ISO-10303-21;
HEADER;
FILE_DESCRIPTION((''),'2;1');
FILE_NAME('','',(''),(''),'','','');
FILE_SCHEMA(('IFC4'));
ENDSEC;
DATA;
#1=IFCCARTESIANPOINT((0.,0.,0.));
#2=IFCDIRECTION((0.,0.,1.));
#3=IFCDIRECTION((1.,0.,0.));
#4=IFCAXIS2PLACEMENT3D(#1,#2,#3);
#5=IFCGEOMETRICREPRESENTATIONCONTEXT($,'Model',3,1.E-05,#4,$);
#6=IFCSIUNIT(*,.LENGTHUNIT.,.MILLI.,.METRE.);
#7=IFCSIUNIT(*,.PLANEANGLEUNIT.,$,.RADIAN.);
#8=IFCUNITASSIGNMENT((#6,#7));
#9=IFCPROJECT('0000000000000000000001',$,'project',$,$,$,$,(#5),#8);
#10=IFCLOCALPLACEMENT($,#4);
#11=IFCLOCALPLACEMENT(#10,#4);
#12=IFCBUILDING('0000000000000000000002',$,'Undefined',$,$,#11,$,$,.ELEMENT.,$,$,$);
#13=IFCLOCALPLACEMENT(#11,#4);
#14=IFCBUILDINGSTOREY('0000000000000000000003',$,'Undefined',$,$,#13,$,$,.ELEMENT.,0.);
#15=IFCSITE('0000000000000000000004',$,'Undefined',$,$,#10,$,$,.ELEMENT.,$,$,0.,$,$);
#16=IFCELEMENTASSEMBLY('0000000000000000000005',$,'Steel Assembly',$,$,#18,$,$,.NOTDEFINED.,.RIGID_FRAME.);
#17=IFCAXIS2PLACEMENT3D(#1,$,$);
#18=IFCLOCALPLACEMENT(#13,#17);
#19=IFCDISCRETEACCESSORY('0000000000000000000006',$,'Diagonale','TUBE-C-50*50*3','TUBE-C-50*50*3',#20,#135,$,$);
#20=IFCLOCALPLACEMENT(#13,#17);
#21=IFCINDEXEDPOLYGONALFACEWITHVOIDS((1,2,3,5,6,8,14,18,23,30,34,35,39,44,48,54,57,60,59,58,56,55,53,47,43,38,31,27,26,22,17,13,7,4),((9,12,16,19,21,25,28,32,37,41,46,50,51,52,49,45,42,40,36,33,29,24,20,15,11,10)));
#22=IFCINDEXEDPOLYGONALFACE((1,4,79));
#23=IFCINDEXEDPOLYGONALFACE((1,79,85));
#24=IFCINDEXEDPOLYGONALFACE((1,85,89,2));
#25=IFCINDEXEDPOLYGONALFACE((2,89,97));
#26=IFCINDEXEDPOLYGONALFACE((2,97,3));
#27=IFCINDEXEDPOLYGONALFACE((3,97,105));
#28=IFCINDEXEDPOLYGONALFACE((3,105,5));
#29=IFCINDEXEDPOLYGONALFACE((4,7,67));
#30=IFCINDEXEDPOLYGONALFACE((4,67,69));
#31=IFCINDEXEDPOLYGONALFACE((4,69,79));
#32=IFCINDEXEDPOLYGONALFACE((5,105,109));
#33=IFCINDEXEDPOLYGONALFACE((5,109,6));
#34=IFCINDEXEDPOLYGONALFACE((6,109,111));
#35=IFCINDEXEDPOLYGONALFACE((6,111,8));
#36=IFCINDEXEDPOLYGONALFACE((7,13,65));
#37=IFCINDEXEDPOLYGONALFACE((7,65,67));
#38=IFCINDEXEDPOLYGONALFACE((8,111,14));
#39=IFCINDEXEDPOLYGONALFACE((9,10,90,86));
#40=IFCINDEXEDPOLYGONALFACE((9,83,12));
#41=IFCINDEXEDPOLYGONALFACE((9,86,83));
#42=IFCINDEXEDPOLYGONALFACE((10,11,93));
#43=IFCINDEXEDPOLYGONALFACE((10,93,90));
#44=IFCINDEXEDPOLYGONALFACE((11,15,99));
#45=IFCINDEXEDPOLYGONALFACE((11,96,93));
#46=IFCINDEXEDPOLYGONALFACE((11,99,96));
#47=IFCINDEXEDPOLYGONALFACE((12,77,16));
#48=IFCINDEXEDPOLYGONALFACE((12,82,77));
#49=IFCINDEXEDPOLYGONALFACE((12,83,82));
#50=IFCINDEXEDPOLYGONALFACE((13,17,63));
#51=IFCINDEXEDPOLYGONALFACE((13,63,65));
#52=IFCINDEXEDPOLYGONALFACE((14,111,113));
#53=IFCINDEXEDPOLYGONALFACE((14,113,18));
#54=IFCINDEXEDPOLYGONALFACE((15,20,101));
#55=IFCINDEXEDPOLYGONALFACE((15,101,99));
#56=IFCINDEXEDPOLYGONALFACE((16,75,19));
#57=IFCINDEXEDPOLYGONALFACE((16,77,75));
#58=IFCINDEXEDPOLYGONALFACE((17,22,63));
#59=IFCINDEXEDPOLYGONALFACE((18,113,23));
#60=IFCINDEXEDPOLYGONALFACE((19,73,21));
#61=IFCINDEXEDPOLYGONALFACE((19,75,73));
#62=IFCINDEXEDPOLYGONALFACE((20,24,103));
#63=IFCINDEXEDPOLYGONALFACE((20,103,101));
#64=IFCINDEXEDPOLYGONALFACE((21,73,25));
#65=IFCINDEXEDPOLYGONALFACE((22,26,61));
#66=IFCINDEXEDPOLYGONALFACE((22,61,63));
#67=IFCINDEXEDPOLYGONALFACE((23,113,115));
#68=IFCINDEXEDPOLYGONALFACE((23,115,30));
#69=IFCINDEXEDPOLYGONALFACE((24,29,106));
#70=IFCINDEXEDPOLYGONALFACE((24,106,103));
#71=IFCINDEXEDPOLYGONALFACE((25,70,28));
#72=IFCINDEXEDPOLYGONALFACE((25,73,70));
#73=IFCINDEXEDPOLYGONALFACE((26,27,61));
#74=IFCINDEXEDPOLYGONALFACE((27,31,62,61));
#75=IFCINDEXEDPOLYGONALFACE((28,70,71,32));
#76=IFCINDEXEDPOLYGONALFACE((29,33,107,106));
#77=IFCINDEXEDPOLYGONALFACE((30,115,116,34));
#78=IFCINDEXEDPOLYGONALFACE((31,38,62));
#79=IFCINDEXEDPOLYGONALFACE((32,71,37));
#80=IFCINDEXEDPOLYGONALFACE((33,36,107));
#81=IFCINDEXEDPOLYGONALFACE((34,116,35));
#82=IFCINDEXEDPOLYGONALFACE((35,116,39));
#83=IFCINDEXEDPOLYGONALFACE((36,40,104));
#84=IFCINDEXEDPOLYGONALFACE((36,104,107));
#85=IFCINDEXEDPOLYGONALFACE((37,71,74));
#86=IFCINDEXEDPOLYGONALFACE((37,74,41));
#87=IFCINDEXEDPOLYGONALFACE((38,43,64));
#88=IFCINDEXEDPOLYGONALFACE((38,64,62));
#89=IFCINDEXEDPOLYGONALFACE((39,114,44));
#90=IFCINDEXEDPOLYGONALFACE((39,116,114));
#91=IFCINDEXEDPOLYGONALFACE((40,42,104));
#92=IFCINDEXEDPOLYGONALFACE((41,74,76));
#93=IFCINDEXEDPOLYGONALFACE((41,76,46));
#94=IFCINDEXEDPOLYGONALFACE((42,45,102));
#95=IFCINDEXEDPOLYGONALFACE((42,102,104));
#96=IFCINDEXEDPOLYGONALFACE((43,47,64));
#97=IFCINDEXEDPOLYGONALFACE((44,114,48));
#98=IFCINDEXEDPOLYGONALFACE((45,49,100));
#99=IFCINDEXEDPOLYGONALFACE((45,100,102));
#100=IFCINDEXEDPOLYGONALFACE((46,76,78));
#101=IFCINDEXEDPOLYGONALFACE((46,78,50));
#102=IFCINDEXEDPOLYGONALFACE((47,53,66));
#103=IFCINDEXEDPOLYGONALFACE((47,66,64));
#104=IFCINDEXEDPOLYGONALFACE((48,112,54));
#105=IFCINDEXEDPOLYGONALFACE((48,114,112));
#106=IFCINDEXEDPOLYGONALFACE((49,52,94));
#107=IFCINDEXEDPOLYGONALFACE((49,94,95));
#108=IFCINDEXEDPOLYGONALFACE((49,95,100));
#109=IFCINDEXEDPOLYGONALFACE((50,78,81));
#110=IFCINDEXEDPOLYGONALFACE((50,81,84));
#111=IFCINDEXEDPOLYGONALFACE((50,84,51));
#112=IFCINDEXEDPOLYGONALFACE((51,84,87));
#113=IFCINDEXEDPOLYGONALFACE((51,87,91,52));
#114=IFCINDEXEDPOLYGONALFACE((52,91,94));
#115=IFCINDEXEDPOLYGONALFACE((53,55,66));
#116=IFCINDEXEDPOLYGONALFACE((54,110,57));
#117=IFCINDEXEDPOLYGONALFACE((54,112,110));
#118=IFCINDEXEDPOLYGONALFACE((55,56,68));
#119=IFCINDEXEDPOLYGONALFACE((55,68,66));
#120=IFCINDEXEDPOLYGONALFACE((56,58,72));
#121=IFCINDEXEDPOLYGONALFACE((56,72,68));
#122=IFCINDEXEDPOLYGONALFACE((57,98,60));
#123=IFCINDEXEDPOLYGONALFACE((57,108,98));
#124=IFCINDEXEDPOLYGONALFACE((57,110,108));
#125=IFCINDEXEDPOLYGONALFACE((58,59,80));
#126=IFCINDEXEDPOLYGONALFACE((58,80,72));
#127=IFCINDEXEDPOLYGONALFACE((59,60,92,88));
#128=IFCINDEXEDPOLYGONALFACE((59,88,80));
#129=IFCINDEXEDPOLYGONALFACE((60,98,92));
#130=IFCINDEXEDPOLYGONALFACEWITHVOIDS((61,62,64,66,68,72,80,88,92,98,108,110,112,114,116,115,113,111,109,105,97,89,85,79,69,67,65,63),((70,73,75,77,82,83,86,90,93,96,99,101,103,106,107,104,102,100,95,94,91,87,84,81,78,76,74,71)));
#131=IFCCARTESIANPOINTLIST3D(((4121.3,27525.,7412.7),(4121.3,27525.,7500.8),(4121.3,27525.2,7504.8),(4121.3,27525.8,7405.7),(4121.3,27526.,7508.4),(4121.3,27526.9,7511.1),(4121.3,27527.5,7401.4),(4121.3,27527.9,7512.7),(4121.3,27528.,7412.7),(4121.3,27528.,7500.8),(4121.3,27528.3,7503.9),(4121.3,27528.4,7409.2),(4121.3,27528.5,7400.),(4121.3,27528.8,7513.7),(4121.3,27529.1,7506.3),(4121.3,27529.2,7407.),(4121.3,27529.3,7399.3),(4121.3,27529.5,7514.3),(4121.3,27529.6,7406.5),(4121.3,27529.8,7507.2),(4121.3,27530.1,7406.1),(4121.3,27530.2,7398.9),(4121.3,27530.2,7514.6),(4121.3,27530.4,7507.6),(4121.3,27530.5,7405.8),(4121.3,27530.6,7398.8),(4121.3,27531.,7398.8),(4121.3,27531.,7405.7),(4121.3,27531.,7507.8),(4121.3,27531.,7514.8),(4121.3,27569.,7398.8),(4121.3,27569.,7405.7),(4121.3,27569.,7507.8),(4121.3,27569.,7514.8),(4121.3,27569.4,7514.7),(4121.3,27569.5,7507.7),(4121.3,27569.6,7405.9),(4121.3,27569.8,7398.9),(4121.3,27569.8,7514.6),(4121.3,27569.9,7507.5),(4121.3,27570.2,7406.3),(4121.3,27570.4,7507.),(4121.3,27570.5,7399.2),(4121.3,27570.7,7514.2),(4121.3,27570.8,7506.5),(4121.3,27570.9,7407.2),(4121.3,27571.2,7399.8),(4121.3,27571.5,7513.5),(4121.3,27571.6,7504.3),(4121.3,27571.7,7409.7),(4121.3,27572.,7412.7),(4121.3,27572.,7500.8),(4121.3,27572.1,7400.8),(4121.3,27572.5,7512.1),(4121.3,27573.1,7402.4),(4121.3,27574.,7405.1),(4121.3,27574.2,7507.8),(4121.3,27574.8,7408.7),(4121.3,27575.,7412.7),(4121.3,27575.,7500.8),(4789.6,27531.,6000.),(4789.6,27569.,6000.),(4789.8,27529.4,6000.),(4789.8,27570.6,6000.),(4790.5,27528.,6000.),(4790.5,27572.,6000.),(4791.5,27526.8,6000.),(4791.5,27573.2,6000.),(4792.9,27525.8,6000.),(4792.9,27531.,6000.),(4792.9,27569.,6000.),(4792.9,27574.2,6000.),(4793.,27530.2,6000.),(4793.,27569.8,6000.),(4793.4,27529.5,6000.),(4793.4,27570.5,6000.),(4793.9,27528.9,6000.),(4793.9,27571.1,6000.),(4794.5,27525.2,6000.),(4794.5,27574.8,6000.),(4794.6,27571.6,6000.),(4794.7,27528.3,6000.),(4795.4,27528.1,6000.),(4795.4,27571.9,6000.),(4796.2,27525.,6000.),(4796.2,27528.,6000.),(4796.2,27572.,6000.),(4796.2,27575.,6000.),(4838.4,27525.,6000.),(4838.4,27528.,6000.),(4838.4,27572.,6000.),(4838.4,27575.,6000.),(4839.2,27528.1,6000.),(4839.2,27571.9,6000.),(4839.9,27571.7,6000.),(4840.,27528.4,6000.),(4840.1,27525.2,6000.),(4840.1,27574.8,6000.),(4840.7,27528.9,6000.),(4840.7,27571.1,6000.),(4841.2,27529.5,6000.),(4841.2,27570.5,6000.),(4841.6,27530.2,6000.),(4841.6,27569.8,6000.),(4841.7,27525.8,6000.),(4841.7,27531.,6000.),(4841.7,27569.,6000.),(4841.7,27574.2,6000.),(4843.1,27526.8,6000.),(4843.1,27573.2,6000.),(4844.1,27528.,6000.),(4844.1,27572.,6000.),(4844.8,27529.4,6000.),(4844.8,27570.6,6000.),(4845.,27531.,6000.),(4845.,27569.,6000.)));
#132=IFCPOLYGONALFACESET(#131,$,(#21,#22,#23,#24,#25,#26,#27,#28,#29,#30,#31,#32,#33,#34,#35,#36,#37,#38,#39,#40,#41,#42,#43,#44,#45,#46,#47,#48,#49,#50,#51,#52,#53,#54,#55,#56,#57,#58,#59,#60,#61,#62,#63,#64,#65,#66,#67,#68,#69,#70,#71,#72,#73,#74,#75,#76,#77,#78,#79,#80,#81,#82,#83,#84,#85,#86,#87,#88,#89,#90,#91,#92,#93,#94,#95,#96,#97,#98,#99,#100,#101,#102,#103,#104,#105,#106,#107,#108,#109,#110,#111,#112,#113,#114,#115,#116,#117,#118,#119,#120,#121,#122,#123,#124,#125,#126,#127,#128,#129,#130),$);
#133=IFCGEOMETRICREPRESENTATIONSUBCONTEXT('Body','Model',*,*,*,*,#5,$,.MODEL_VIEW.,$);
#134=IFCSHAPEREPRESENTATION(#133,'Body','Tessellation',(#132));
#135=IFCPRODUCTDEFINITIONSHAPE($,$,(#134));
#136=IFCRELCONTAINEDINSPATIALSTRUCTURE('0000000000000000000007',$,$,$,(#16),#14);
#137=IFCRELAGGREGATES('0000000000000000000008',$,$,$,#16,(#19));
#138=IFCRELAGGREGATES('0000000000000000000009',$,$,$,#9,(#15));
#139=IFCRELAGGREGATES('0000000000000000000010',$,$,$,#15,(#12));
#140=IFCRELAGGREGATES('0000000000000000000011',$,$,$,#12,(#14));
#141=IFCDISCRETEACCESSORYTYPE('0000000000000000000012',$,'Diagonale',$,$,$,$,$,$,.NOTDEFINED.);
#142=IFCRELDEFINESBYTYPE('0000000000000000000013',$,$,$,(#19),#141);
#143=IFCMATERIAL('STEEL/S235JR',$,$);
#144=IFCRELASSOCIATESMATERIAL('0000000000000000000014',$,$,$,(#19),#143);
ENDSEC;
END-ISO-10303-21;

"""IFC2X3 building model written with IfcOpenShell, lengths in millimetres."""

from ifc_helpers import new_model, si_unit, frame, origin_with_axes, origin_2d_with_axis, place, context, subcontext, project, spatial, hollow_rectangle, extrude, clip, halfspace, material, type_object, element, aggregate, save


model = new_model("IFC2X3")

# Units and contexts
model_context = context("Model", 3, precision=1e-05, world=origin_with_axes())
body_context = subcontext(model_context, "Body", "Model", "MODEL_VIEW")
ifc_project = project(units=[si_unit("LENGTHUNIT", "METRE", prefix="MILLI"), si_unit("PLANEANGLEUNIT", "RADIAN")], contexts=[model_context])

# Site, building, storey
site_placement = place(None, origin_with_axes())
site = spatial("IfcSite", under=ifc_project, at=site_placement, Name="Undefined", CompositionType="ELEMENT", RefElevation=0.0)
building_placement = place(site_placement, origin_with_axes())
building = spatial("IfcBuilding", under=site, at=building_placement, Name="Undefined", CompositionType="ELEMENT")
storey_placement = place(building_placement, origin_with_axes())
storey = spatial("IfcBuildingStorey", under=building, at=storey_placement, Name="Undefined", CompositionType="ELEMENT", Elevation=0.0)

# Element assembly
assembly_1_placement = place(storey_placement, origin_with_axes())
assembly_1 = element("IfcElementAssembly", 1, at=assembly_1_placement, inside=storey, Name="Steel Assembly", AssemblyPlace="NOTDEFINED", PredefinedType="RIGID_FRAME")
ifc_material_1 = material(Name="STEEL/S235JR")

# Discrete accessory
discrete_accessory_type_1 = type_object("IfcDiscreteAccessoryType", Name="Diagonale")
discrete_accessory_1_placement = place(assembly_1_placement, frame((4822.4, 27550.0, 5989.2), z_axis=(0.902299, 0.0, 0.431112), x_axis=(-0.431112, 0.0, 0.902299)))
discrete_accessory_1 = element("IfcDiscreteAccessory", 2, at=discrete_accessory_1_placement, type_object=discrete_accessory_type_1, material=ifc_material_1, Name="Diagonale", Description="TUBE-C-50*50*3", ObjectType="TUBE-C-50*50*3", context=body_context, shape_type="Clipping", body=[
    clip(clip(extrude(hollow_rectangle(XDim=50.0, YDim=50.0, WallThickness=3.0, InnerFilletRadius=3.0, OuterFilletRadius=6.0, at=origin_2d_with_axis()), frame((1691.4, 0.0, 0.0), z_axis=(-1.0, 0.0, 0.0), x_axis=(0.0, -1.0, 0.0)), (0.0, 0.0, 1.0), 1744.3), halfspace(frame((1662.5, 0.0, 17.2), z_axis=(-0.431112, 0.0, 0.902299), x_axis=(-0.902299, 0.0, -0.431112)), True)), halfspace(frame((34.2, 0.0, -46.6), z_axis=(0.902299, 0.0, 0.431112), x_axis=(-0.431112, 0.0, 0.902299)), True)),
])

aggregate(assembly_1, [discrete_accessory_1])

save(model, "model.ifc")
